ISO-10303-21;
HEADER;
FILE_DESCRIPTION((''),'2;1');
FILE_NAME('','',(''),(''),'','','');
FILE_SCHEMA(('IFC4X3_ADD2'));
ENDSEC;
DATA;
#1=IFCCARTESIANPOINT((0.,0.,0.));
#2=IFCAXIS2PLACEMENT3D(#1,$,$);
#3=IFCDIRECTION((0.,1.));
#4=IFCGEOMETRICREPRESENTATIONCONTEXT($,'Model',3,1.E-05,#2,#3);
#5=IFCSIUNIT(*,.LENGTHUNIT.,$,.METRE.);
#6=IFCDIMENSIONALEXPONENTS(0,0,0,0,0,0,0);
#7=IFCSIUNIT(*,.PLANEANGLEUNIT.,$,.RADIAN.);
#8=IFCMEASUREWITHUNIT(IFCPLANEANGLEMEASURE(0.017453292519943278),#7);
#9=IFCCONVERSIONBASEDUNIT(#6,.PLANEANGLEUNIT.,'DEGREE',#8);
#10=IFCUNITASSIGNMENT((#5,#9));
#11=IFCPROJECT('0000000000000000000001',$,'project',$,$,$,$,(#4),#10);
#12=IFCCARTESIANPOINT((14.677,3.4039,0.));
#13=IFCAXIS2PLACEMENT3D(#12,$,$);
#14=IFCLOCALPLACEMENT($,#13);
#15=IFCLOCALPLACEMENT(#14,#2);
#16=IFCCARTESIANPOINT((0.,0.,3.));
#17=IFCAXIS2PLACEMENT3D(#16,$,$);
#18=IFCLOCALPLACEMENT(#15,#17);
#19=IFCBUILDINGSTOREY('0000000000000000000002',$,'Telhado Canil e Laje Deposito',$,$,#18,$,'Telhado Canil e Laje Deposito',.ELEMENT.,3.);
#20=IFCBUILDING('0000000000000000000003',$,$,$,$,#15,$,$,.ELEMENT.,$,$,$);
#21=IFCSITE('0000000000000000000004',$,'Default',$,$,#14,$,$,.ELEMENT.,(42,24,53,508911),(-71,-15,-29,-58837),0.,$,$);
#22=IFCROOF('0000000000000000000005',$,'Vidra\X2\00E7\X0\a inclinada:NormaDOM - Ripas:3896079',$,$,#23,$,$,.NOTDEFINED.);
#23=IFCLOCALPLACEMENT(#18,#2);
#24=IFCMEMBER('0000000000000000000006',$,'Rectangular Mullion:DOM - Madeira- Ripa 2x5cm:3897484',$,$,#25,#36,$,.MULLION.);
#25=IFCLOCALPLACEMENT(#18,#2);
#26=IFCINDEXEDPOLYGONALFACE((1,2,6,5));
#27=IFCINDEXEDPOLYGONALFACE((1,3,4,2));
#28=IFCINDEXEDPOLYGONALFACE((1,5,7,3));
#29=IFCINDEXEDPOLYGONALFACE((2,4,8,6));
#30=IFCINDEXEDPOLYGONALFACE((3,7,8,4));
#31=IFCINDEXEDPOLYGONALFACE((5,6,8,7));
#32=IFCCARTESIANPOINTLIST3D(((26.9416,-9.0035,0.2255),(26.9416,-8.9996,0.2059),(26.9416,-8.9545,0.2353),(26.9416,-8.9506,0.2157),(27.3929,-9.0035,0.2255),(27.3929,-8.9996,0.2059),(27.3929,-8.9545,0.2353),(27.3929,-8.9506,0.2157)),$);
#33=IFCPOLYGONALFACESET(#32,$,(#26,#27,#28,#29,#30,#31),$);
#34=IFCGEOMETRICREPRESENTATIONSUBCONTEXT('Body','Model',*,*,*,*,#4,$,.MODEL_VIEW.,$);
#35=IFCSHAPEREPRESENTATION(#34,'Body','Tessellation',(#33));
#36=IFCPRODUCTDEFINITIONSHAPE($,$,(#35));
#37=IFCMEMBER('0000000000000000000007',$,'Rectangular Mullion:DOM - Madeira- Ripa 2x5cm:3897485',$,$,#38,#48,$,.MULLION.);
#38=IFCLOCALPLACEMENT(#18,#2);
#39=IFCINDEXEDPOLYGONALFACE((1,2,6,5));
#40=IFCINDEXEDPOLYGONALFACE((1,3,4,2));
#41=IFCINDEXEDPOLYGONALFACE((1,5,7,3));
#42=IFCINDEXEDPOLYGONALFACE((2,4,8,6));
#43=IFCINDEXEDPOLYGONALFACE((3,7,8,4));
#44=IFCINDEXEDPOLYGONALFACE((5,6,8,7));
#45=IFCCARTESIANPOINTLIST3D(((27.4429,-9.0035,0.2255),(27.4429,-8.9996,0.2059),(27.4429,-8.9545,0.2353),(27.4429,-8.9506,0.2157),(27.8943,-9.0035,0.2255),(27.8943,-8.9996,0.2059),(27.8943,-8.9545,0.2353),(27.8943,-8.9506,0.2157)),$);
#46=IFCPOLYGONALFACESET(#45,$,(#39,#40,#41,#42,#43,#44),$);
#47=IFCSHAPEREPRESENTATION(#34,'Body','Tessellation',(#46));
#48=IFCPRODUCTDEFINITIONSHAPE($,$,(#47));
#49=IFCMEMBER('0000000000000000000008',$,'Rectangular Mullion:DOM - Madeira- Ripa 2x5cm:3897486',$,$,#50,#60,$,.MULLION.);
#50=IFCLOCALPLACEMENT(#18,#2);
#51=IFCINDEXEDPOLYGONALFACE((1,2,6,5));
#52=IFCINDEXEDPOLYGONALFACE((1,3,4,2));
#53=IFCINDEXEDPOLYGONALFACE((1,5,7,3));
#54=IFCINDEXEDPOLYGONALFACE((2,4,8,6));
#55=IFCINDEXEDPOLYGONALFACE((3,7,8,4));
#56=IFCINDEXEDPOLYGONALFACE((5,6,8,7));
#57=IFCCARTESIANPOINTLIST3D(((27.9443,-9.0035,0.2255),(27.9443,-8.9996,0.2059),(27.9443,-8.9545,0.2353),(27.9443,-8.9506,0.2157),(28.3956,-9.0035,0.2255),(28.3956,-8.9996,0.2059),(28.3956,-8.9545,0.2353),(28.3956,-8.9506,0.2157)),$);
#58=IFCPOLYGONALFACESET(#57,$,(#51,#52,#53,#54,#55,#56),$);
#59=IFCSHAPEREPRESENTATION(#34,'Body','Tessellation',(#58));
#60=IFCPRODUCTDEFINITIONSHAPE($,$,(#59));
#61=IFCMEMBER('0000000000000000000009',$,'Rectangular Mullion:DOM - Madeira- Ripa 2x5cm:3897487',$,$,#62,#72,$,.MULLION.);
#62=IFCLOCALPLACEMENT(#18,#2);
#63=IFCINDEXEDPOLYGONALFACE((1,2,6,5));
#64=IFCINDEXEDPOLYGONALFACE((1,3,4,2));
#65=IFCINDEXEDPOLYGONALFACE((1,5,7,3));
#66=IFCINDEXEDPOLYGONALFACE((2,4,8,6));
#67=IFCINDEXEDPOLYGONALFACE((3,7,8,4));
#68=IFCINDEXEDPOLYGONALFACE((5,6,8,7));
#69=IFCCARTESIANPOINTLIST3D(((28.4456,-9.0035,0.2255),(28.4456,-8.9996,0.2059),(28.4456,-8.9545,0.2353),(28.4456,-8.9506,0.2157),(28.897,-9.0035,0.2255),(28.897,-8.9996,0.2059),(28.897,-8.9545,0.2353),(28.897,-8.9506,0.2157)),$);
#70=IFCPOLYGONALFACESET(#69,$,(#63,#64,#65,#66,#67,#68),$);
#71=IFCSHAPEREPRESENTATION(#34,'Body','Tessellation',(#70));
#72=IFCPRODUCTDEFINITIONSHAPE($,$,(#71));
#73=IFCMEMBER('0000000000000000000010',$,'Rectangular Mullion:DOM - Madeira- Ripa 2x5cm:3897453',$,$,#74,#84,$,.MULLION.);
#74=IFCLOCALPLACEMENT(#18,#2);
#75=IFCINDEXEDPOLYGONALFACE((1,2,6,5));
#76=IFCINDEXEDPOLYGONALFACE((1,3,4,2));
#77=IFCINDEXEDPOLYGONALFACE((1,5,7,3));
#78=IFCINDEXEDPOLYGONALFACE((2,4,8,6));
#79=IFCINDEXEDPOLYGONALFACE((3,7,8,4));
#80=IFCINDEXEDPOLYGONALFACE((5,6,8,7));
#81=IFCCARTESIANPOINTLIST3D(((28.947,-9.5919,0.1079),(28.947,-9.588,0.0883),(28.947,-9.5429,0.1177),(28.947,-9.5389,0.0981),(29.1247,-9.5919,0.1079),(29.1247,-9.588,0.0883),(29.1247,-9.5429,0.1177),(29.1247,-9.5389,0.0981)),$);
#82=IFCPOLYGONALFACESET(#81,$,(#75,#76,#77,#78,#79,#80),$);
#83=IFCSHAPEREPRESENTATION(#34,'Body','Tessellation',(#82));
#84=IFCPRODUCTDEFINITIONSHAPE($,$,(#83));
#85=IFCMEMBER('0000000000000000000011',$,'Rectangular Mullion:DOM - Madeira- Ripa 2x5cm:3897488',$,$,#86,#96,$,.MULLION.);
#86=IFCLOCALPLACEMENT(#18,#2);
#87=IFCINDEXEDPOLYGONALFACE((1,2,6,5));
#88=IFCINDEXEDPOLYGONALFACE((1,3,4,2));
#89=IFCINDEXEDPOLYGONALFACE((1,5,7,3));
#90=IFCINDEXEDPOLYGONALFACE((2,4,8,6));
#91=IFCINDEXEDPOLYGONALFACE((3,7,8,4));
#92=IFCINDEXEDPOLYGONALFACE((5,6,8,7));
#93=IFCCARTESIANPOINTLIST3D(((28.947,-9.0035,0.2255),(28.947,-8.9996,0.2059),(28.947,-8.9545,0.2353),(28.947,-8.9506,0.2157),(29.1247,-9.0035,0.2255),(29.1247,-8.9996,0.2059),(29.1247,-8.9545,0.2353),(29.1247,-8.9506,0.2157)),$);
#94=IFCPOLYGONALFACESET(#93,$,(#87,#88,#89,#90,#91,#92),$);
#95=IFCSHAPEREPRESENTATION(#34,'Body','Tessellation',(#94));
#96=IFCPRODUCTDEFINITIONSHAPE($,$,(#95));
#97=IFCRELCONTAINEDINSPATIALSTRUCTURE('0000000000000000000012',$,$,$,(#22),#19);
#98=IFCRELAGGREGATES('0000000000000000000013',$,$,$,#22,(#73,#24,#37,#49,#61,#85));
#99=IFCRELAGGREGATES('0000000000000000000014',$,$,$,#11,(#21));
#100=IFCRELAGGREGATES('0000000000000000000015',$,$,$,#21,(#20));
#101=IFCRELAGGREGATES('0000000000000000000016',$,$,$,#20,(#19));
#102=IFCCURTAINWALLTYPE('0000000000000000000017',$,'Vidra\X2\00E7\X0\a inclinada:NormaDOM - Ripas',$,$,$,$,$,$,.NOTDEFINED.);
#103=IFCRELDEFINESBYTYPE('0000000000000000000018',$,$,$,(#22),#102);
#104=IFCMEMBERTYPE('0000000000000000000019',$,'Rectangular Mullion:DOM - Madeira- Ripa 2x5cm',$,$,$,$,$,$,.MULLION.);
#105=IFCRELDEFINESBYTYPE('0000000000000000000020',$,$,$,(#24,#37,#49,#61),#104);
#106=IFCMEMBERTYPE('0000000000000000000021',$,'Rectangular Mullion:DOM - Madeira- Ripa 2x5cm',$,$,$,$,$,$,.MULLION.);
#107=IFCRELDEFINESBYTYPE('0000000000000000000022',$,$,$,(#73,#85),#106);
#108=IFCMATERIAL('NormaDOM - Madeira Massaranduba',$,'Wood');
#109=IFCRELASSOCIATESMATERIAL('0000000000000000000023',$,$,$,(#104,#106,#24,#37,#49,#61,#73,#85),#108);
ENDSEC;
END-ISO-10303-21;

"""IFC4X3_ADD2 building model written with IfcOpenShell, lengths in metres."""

from ifc_helpers import new_model, entity, si_unit, converted_unit, direction, frame, origin, origin_2d_with_axis, place, context, subcontext, project, spatial, rectangle, extrude, source, transform, mapped, material, material_profile, profile_set, profile_usage, type_object, type_shapes, element, aggregate, save


model = new_model("IFC4X3_ADD2")

# Units and contexts
model_context = context("Model", 3, precision=1e-05, world=origin(), true_north=direction((0.0, 1.0)))
body_context = subcontext(model_context, "Body", "Model", "MODEL_VIEW")
ifc_project = project(units=[si_unit("LENGTHUNIT", "METRE"), converted_unit("PLANEANGLEUNIT", "DEGREE", entity("IfcPlaneAngleMeasure", 0.017453292519943278), si_unit("PLANEANGLEUNIT", "RADIAN"), dimensions=[0, 0, 0, 0, 0, 0, 0])], contexts=[model_context])

# Site, building, storey
site_placement = place(None, frame((14.677, 3.4039, 0.0)))
site = spatial("IfcSite", under=ifc_project, at=site_placement, Name="Default", CompositionType="ELEMENT", RefLatitude=(42, 24, 53, 508911), RefLongitude=(-71, -15, -29, -58837), RefElevation=0.0)
building_placement = place(site_placement, origin())
building = spatial("IfcBuilding", under=site, at=building_placement, CompositionType="ELEMENT")
storey_placement = place(building_placement, frame((0.0, 0.0, 3.0)))
storey = spatial("IfcBuildingStorey", under=building, at=storey_placement, Name="Telhado Canil e Laje Deposito", LongName="Telhado Canil e Laje Deposito", CompositionType="ELEMENT", Elevation=3.0)

# Shared definitions
ifc_material = material(Name="NormaDOM - Madeira Massaranduba", Category="Wood")

# Roof
curtain_wall_type_1 = type_object("IfcCurtainWallType", Name="Vidraça inclinada:NormaDOM - Ripas", PredefinedType="NOTDEFINED")
roof_1_placement = place(storey_placement, frame((0.0, 0.0, -3.0)))
roof_1 = element("IfcRoof", 1, at=roof_1_placement, inside=storey, type_object=curtain_wall_type_1, Name="Vidraça inclinada:NormaDOM - Ripas:3896079", PredefinedType="NOTDEFINED")

# Members
ifc_material_profile_1 = material_profile(ifc_material, rectangle(XDim=0.05, YDim=0.02, at=origin_2d_with_axis()), Name="DOM - Madeira- Ripa 2x5cm")
ifc_profile_set_1 = profile_set([ifc_material_profile_1], Name="DOM - Madeira- Ripa 2x5cm")
ifc_profile_usage_1 = profile_usage(ifc_profile_set_1)
member_type_1 = type_object("IfcMemberType", Name="Rectangular Mullion:DOM - Madeira- Ripa 2x5cm", PredefinedType="MULLION", material=ifc_profile_set_1)
shared_shape_1 = source(origin(), body_context, "Body", "SweptSolid", [
    extrude(rectangle(XDim=0.05, YDim=0.02, at=origin_2d_with_axis()), frame((0.025, 0.01, -0.4514), z_axis=(0.0, 0.0, 1.0), x_axis=(-1.0, 0.0, 0.0)), (0.0, 0.0, 1.0), 0.4514),
])
type_shapes(member_type_1, [shared_shape_1])
member_1_placement = place(roof_1_placement, frame((26.9416, -9.0035, 3.2255), z_axis=(-1.0, 0.0, 0.0), x_axis=(0.0, 0.980581, 0.196116)))
member_1 = element("IfcMember", 2, at=member_1_placement, type_object=member_type_1, material=ifc_profile_usage_1, Name="Rectangular Mullion:DOM - Madeira- Ripa 2x5cm:3897484", PredefinedType="MULLION", context=body_context, shape_type="MappedRepresentation", body=[
    mapped(shared_shape_1, transform((0.0, 0.0, 0.0), scale=1.0)),
])
member_2_placement = place(roof_1_placement, frame((27.4429, -9.0035, 3.2255), z_axis=(-1.0, 0.0, 0.0), x_axis=(0.0, 0.980581, 0.196116)))
member_2 = element("IfcMember", 3, at=member_2_placement, type_object=member_type_1, material=ifc_profile_usage_1, Name="Rectangular Mullion:DOM - Madeira- Ripa 2x5cm:3897485", PredefinedType="MULLION", context=body_context, shape_type="MappedRepresentation", body=[
    mapped(shared_shape_1, transform((0.0, 0.0, 0.0), scale=1.0)),
])
member_3_placement = place(roof_1_placement, frame((27.9443, -9.0035, 3.2255), z_axis=(-1.0, 0.0, 0.0), x_axis=(0.0, 0.980581, 0.196116)))
member_3 = element("IfcMember", 4, at=member_3_placement, type_object=member_type_1, material=ifc_profile_usage_1, Name="Rectangular Mullion:DOM - Madeira- Ripa 2x5cm:3897486", PredefinedType="MULLION", context=body_context, shape_type="MappedRepresentation", body=[
    mapped(shared_shape_1, transform((0.0, 0.0, 0.0), scale=1.0)),
])
member_4_placement = place(roof_1_placement, frame((28.4456, -9.0035, 3.2255), z_axis=(-1.0, 0.0, 0.0), x_axis=(0.0, 0.980581, 0.196116)))
member_4 = element("IfcMember", 5, at=member_4_placement, type_object=member_type_1, material=ifc_profile_usage_1, Name="Rectangular Mullion:DOM - Madeira- Ripa 2x5cm:3897487", PredefinedType="MULLION", context=body_context, shape_type="MappedRepresentation", body=[
    mapped(shared_shape_1, transform((0.0, 0.0, 0.0), scale=1.0)),
])
member_type_2 = type_object("IfcMemberType", Name="Rectangular Mullion:DOM - Madeira- Ripa 2x5cm", PredefinedType="MULLION", material=ifc_profile_set_1)
shared_shape_2 = source(origin(), body_context, "Body", "SweptSolid", [
    extrude(rectangle(XDim=0.05, YDim=0.02, at=origin_2d_with_axis()), frame((0.025, 0.01, -0.1777), z_axis=(0.0, 0.0, 1.0), x_axis=(-1.0, 0.0, 0.0)), (0.0, 0.0, 1.0), 0.1777),
])
type_shapes(member_type_2, [shared_shape_2])
member_5_placement = place(roof_1_placement, frame((28.947, -9.5919, 3.1079), z_axis=(-1.0, 0.0, 0.0), x_axis=(0.0, 0.980581, 0.196116)))
member_5 = element("IfcMember", 6, at=member_5_placement, type_object=member_type_2, material=ifc_profile_usage_1, Name="Rectangular Mullion:DOM - Madeira- Ripa 2x5cm:3897453", PredefinedType="MULLION", context=body_context, shape_type="MappedRepresentation", body=[
    mapped(shared_shape_2, transform((0.0, 0.0, 0.0), scale=1.0)),
])
member_6_placement = place(roof_1_placement, frame((28.947, -9.0035, 3.2255), z_axis=(-1.0, 0.0, 0.0), x_axis=(0.0, 0.980581, 0.196116)))
member_6 = element("IfcMember", 7, at=member_6_placement, type_object=member_type_2, material=ifc_profile_usage_1, Name="Rectangular Mullion:DOM - Madeira- Ripa 2x5cm:3897488", PredefinedType="MULLION", context=body_context, shape_type="MappedRepresentation", body=[
    mapped(shared_shape_2, transform((0.0, 0.0, 0.0), scale=1.0)),
])
aggregate(roof_1, [member_5, member_1, member_2, member_3, member_4, member_6])

save(model, "model.ifc")
